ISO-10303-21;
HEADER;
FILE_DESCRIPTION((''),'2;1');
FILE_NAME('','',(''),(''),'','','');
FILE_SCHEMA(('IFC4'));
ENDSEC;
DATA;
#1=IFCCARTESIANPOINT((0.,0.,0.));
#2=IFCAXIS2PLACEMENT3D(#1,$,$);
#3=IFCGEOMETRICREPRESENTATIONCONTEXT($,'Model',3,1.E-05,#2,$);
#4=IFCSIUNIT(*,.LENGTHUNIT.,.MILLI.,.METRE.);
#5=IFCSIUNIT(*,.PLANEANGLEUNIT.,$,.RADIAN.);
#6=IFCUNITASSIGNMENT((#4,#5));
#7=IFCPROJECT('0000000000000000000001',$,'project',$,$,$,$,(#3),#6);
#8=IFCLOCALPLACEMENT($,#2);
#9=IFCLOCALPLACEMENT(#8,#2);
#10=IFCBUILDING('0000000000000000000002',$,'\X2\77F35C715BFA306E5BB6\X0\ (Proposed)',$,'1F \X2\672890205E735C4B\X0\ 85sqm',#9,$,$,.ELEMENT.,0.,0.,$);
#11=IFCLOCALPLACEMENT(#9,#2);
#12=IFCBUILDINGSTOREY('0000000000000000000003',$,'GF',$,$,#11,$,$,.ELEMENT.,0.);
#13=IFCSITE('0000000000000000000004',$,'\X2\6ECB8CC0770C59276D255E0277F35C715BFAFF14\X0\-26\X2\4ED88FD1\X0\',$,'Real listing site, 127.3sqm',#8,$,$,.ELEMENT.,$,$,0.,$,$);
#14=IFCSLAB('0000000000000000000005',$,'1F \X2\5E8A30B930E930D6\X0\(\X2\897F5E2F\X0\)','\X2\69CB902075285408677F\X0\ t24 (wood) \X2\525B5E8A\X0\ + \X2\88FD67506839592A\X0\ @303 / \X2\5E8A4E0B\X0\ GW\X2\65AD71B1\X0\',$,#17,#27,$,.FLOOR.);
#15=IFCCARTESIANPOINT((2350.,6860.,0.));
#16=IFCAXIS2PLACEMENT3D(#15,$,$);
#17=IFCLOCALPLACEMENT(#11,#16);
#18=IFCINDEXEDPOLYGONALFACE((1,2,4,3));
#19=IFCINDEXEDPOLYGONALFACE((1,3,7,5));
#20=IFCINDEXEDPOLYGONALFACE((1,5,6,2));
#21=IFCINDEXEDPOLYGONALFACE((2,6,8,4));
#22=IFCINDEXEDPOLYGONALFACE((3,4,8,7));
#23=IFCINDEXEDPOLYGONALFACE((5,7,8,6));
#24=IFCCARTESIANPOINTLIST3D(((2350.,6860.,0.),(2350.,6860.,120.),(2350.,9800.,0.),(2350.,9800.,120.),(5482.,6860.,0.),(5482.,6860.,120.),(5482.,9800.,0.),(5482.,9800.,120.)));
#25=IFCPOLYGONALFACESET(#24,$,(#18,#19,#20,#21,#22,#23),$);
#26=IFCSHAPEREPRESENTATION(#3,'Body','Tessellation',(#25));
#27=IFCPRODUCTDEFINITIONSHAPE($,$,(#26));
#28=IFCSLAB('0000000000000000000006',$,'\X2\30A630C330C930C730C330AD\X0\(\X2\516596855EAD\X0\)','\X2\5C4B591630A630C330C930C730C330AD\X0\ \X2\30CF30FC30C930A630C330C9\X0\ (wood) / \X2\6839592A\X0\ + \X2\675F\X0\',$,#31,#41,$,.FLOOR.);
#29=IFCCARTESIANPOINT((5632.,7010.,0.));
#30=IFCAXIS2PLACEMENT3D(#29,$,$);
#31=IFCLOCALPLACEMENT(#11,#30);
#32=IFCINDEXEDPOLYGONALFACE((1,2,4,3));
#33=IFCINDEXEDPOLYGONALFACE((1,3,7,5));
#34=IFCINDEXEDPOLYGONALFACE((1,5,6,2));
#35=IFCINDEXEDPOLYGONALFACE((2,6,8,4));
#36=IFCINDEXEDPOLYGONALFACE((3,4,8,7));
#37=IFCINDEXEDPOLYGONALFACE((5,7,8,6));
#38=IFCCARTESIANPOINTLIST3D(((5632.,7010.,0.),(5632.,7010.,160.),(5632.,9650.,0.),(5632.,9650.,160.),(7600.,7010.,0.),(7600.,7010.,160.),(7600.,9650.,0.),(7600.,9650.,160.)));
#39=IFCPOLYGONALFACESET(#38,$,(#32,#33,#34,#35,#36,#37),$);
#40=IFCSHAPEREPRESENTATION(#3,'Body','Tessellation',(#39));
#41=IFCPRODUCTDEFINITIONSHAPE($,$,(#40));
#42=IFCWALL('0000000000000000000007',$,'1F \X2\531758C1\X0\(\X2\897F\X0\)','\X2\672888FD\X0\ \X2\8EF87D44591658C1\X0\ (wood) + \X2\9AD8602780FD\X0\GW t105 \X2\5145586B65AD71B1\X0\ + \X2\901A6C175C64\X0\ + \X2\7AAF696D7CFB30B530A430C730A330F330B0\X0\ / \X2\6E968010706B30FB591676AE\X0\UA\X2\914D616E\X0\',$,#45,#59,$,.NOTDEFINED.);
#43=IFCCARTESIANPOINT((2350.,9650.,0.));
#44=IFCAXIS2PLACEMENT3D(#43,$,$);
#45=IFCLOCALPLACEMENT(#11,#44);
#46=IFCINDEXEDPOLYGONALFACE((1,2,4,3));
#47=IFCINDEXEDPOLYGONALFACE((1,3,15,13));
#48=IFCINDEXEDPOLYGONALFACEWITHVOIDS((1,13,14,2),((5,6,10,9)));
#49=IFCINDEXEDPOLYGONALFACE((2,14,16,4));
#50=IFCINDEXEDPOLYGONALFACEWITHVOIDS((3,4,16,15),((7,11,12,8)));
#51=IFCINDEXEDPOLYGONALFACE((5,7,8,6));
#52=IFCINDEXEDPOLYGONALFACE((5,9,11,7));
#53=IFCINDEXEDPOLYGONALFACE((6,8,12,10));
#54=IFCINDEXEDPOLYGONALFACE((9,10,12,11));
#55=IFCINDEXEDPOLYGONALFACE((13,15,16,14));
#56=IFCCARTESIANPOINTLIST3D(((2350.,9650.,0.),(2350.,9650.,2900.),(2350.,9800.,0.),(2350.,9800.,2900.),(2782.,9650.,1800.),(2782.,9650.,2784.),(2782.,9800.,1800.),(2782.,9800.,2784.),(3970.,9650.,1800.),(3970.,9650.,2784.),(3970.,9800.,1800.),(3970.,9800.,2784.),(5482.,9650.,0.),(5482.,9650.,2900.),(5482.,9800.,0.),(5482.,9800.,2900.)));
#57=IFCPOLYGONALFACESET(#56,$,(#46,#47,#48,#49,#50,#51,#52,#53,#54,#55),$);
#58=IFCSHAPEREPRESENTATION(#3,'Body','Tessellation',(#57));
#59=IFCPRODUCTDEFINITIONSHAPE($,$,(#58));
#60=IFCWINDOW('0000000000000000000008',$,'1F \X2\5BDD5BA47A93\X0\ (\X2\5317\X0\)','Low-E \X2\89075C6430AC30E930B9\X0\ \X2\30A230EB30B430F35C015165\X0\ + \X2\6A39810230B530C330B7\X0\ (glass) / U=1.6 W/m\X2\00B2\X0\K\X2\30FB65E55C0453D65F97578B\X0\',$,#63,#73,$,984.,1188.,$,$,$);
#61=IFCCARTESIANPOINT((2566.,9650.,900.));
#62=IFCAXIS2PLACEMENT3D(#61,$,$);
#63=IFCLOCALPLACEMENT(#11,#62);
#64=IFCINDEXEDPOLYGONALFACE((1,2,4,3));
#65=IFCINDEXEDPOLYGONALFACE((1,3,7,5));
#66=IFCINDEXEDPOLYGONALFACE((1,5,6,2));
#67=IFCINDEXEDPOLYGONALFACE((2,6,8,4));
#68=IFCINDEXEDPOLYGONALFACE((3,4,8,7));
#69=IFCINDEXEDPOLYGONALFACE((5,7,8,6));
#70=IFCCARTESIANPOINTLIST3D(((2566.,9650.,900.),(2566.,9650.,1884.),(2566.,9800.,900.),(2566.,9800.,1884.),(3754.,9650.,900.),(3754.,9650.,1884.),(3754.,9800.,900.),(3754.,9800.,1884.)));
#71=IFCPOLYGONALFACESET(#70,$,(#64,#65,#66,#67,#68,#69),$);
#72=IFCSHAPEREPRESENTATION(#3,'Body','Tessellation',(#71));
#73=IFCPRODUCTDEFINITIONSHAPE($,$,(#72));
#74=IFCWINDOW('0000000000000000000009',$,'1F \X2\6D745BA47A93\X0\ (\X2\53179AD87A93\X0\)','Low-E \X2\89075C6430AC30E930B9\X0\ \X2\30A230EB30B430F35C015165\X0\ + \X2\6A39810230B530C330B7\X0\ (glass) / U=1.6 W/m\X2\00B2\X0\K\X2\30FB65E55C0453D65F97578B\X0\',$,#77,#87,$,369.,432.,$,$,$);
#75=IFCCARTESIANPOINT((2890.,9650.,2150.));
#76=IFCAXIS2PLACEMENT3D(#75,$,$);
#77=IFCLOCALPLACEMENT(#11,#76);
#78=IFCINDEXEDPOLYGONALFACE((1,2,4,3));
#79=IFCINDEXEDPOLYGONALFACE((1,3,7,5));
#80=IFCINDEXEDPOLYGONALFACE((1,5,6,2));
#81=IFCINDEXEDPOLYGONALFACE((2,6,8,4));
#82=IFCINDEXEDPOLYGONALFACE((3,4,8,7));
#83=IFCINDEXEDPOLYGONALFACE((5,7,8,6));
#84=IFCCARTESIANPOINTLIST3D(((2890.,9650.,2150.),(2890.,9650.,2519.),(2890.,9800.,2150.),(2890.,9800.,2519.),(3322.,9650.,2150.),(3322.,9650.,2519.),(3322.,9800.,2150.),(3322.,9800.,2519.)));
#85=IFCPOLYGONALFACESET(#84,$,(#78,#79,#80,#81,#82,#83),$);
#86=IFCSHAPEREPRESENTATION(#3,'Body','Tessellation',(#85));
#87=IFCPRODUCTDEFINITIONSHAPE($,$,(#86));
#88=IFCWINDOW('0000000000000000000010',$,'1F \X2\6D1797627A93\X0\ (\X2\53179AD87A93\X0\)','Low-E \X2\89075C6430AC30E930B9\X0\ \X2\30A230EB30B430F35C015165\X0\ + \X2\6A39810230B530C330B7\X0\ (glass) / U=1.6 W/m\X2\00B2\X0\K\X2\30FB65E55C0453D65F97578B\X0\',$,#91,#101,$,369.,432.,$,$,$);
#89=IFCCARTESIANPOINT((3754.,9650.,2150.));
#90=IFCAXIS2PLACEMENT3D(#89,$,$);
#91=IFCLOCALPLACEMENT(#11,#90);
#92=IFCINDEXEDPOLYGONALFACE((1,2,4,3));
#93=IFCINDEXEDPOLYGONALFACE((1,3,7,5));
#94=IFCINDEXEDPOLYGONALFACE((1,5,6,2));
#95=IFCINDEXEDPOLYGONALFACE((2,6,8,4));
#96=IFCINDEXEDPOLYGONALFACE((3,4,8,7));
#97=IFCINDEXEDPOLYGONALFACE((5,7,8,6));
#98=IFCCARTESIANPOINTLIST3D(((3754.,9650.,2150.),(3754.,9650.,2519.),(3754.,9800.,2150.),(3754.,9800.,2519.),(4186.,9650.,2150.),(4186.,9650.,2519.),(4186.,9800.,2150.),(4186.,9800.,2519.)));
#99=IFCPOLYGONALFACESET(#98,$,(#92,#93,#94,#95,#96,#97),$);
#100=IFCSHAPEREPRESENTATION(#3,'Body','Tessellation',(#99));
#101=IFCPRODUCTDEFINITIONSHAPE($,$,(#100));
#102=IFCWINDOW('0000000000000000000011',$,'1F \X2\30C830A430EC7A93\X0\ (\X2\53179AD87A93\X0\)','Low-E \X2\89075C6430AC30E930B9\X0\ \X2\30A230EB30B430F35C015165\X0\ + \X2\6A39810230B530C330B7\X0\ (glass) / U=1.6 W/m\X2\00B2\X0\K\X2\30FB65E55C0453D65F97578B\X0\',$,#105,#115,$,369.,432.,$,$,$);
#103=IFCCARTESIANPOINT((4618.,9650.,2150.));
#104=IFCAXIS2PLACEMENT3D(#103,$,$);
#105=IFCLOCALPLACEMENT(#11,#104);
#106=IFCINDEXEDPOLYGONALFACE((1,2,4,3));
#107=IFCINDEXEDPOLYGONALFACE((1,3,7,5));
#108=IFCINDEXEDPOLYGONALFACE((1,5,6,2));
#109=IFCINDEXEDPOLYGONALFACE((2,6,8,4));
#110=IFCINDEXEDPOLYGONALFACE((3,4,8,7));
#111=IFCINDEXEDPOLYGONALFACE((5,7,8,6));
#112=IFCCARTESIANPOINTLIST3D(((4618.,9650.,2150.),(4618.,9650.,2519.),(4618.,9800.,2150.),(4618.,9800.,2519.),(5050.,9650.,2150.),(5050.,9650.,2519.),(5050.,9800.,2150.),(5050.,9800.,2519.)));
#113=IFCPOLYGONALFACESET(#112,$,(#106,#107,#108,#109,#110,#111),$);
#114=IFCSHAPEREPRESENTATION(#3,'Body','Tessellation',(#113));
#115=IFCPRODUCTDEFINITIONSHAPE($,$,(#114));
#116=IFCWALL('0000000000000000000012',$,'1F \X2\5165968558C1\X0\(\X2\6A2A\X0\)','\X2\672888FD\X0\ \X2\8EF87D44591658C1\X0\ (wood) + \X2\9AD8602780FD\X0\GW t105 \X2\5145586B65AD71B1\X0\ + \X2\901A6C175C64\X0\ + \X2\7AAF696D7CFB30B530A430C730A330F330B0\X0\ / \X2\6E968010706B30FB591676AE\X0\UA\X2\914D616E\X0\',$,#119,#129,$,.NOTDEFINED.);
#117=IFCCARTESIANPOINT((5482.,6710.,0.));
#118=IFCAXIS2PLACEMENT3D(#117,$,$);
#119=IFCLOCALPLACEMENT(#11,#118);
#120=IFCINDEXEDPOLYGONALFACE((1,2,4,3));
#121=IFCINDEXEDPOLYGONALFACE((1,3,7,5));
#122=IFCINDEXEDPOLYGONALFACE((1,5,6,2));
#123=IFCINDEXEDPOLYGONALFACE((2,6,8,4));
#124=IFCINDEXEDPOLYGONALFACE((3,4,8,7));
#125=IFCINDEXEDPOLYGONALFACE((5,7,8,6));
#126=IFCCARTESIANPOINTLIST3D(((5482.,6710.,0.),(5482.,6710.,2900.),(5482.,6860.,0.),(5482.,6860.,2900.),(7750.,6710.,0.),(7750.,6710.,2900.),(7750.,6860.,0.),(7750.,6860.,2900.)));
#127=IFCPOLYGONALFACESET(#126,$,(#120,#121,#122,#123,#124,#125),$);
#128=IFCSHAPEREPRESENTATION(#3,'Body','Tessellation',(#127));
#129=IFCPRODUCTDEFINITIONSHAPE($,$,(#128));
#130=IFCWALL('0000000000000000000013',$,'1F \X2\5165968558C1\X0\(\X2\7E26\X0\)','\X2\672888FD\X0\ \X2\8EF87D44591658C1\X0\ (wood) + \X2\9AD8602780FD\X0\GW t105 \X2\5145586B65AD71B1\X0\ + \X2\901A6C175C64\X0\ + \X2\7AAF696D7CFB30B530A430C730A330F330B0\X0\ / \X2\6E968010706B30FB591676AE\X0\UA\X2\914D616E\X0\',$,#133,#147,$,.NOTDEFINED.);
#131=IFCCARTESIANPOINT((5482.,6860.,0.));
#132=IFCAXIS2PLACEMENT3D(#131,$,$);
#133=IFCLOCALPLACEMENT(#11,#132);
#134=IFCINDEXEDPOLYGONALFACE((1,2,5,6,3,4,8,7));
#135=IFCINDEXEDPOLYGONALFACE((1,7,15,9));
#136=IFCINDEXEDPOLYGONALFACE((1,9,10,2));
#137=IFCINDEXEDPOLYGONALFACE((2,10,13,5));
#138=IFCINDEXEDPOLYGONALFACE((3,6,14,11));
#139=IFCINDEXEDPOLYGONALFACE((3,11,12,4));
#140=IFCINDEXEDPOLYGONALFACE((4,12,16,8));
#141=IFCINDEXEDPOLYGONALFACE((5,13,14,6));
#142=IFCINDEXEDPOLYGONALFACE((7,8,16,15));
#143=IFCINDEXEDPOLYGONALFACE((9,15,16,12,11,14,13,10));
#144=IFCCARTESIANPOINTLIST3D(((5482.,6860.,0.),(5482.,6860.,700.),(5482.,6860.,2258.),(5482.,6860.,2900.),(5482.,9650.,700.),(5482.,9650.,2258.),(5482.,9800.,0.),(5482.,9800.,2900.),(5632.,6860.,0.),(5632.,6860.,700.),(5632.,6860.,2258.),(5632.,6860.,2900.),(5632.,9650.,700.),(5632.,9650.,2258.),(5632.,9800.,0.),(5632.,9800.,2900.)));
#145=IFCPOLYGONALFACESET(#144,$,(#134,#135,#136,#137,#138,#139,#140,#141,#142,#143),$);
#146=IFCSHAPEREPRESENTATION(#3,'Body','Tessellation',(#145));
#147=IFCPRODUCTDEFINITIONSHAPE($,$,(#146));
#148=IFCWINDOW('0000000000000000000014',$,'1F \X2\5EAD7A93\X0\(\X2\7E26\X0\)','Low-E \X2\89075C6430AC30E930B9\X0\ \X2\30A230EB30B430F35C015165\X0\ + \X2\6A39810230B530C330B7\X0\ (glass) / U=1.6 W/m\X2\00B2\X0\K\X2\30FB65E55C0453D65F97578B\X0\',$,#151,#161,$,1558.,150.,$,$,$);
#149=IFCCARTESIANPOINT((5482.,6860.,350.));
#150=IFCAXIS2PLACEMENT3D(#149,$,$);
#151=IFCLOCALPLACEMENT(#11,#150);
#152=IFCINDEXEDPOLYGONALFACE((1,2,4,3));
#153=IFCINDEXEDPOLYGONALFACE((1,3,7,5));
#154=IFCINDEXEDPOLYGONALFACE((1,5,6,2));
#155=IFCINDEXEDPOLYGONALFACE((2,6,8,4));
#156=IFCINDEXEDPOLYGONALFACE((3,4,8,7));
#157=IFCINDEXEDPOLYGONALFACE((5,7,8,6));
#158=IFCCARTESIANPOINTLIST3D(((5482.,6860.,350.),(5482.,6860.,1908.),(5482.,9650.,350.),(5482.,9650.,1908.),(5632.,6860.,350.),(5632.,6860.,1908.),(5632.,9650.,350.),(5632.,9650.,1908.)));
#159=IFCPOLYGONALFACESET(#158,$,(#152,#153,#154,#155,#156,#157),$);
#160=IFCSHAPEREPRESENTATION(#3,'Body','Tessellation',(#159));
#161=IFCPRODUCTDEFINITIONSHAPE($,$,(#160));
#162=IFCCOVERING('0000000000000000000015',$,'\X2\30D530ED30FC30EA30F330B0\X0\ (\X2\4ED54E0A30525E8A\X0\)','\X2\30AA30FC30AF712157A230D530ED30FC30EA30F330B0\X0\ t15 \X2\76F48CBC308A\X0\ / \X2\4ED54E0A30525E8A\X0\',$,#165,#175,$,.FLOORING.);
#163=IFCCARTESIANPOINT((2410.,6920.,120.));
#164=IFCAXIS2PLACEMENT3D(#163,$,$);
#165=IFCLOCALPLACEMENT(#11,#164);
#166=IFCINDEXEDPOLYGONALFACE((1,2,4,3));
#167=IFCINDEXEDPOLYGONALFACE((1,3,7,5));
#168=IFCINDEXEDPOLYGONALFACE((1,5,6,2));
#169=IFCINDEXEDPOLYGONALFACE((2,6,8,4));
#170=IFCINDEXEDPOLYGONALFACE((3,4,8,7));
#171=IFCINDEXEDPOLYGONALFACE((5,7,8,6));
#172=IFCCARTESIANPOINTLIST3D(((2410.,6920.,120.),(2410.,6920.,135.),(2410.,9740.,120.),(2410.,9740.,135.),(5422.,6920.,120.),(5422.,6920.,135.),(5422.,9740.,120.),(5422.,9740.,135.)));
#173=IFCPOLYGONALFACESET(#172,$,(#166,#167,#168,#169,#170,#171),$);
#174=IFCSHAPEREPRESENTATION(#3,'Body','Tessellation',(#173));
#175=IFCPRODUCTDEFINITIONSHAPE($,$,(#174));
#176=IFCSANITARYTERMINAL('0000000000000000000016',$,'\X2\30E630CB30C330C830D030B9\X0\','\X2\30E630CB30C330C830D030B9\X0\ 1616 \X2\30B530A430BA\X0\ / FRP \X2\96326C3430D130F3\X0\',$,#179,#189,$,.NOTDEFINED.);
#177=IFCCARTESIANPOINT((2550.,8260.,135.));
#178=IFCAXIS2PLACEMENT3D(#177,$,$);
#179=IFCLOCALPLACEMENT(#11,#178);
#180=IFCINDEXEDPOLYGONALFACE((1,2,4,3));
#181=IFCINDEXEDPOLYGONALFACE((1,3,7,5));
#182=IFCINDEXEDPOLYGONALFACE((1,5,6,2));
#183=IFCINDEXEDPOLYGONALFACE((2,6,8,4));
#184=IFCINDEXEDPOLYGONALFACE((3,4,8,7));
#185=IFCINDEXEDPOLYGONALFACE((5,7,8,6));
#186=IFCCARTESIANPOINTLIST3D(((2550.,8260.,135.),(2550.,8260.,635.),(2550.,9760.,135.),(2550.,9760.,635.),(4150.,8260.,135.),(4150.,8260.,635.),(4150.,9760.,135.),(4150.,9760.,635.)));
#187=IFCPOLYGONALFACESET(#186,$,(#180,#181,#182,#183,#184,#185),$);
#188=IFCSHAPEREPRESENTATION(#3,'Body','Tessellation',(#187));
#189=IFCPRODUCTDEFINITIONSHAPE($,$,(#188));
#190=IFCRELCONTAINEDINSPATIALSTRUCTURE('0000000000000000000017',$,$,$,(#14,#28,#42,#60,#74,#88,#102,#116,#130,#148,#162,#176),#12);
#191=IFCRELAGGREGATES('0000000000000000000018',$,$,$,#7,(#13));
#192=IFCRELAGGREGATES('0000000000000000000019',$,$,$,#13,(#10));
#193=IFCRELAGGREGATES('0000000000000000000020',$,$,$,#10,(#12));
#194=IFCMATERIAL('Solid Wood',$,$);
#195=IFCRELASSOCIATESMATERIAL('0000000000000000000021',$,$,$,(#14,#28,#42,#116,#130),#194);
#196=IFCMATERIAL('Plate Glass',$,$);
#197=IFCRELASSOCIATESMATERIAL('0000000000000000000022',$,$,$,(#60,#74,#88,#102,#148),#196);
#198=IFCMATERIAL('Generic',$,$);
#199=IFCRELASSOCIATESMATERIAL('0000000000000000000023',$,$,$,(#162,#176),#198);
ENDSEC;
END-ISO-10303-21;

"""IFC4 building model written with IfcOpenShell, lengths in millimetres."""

from ifc_helpers import new_model, si_unit, frame, frame_2d, origin, place, context, project, spatial, rectangle, extrude, material, element, fill, save


model = new_model("IFC4")

# Units and contexts
model_context = context("Model", 3, precision=1e-05, world=origin())
ifc_project = project(units=[si_unit("LENGTHUNIT", "METRE", prefix="MILLI"), si_unit("PLANEANGLEUNIT", "RADIAN")], contexts=[model_context])

# Site, building, storey
site_placement = place(None, origin())
site = spatial("IfcSite", under=ifc_project, at=site_placement, Name="滋賀県大津市石山寺４-26付近", ObjectType="Real listing site, 127.3sqm", CompositionType="ELEMENT", RefElevation=0.0)
building_placement = place(site_placement, origin())
building = spatial("IfcBuilding", under=site, at=building_placement, Name="石山寺の家 (Proposed)", ObjectType="1F 木造平屋 85sqm", CompositionType="ELEMENT", ElevationOfRefHeight=0.0, ElevationOfTerrain=0.0)
storey_placement = place(building_placement, origin())
storey = spatial("IfcBuildingStorey", under=building, at=storey_placement, Name="GF", CompositionType="ELEMENT", Elevation=0.0)

# Slabs
ifc_material_1 = material(Name="Solid Wood")
slab_1_placement = place(storey_placement, frame((2350.0, 6860.0, 0.0)))
element("IfcSlab", 1, at=slab_1_placement, inside=storey, material=ifc_material_1, Name="1F 床スラブ(西帯)", Description="構造用合板 t24 (wood) 剛床 + 製材根太 @303 / 床下 GW断熱", PredefinedType="FLOOR", context=model_context, shape_type="SweptSolid", body=[
    extrude(rectangle(XDim=3132.0, YDim=2940.0, at=frame_2d((1566.0, 1470.0))), frame((2350.0, 6860.0, 0.0)), (0.0, 0.0, 1.0), 120.0),
])
slab_2_placement = place(storey_placement, frame((5632.0, 7010.0, 0.0)))
element("IfcSlab", 2, at=slab_2_placement, inside=storey, material=ifc_material_1, Name="ウッドデッキ(入隅庭)", Description="屋外ウッドデッキ ハードウッド (wood) / 根太 + 束", PredefinedType="FLOOR", context=model_context, shape_type="SweptSolid", body=[
    extrude(rectangle(XDim=1968.0, YDim=2640.0, at=frame_2d((984.0, 1320.0))), frame((5632.0, 7010.0, 0.0)), (0.0, 0.0, 1.0), 160.0),
])

# Wall, openings, windows
wall_1_placement = place(storey_placement, frame((2350.0, 9650.0, 0.0)))
wall_1 = element("IfcWall", 3, at=wall_1_placement, inside=storey, material=ifc_material_1, Name="1F 北壁(西)", Description="木製 軸組外壁 (wood) + 高性能GW t105 充填断熱 + 通気層 + 窯業系サイディング / 準耐火・外皮UA配慮", PredefinedType="NOTDEFINED", context=model_context, shape_type="SweptSolid", body=[
    extrude(rectangle(XDim=3132.0, YDim=150.0, at=frame_2d((1566.0, 75.0))), frame((2350.0, 9650.0, 0.0)), (0.0, 0.0, 1.0), 2900.0),
])
opening_1_placement = place(storey_placement, frame((2566.0, 9650.0, 900.0)))
opening_1 = element("IfcOpeningElement", 4, at=opening_1_placement, cuts=wall_1, PredefinedType="NOTDEFINED", context=model_context, shape_type="SweptSolid", body=[
    extrude(rectangle(XDim=1188.0, YDim=150.0, at=frame_2d((594.0, 75.0))), frame((2566.0, 9650.0, 900.0)), (0.0, 0.0, 1.0), 984.0),
])
opening_2_placement = place(storey_placement, frame((2890.0, 9650.0, 2150.0)))
opening_2 = element("IfcOpeningElement", 5, at=opening_2_placement, cuts=wall_1, PredefinedType="NOTDEFINED", context=model_context, shape_type="SweptSolid", body=[
    extrude(rectangle(XDim=432.0, YDim=150.0, at=frame_2d((216.0, 75.0))), frame((2890.0, 9650.0, 2150.0)), (0.0, 0.0, 1.0), 369.0),
])
opening_3_placement = place(storey_placement, frame((3754.0, 9650.0, 2150.0)))
opening_3 = element("IfcOpeningElement", 6, at=opening_3_placement, cuts=wall_1, PredefinedType="NOTDEFINED", context=model_context, shape_type="SweptSolid", body=[
    extrude(rectangle(XDim=432.0, YDim=150.0, at=frame_2d((216.0, 75.0))), frame((3754.0, 9650.0, 2150.0)), (0.0, 0.0, 1.0), 369.0),
])
opening_4_placement = place(storey_placement, frame((4618.0, 9650.0, 2150.0)))
opening_4 = element("IfcOpeningElement", 7, at=opening_4_placement, cuts=wall_1, PredefinedType="NOTDEFINED", context=model_context, shape_type="SweptSolid", body=[
    extrude(rectangle(XDim=432.0, YDim=150.0, at=frame_2d((216.0, 75.0))), frame((4618.0, 9650.0, 2150.0)), (0.0, 0.0, 1.0), 369.0),
])
ifc_material_2 = material(Name="Plate Glass")
window_1_placement = place(storey_placement, frame((2566.0, 9650.0, 900.0)))
window_1 = element("IfcWindow", 8, at=window_1_placement, inside=storey, material=ifc_material_2, Name="1F 寝室窓 (北)", Description="Low-E 複層ガラス アルゴン封入 + 樹脂サッシ (glass) / U=1.6 W/m²K・日射取得型", OverallHeight=984.0, OverallWidth=1188.0, context=model_context, shape_type="SweptSolid", body=[
    extrude(rectangle(XDim=1188.0, YDim=150.0, at=frame_2d((594.0, 75.0))), frame((2566.0, 9650.0, 900.0)), (0.0, 0.0, 1.0), 984.0),
])
fill(opening_1, window_1)
window_2_placement = place(storey_placement, frame((2890.0, 9650.0, 2150.0)))
window_2 = element("IfcWindow", 9, at=window_2_placement, inside=storey, material=ifc_material_2, Name="1F 浴室窓 (北高窓)", Description="Low-E 複層ガラス アルゴン封入 + 樹脂サッシ (glass) / U=1.6 W/m²K・日射取得型", OverallHeight=369.0, OverallWidth=432.0, context=model_context, shape_type="SweptSolid", body=[
    extrude(rectangle(XDim=432.0, YDim=150.0, at=frame_2d((216.0, 75.0))), frame((2890.0, 9650.0, 2150.0)), (0.0, 0.0, 1.0), 369.0),
])
fill(opening_2, window_2)
window_3_placement = place(storey_placement, frame((3754.0, 9650.0, 2150.0)))
window_3 = element("IfcWindow", 10, at=window_3_placement, inside=storey, material=ifc_material_2, Name="1F 洗面窓 (北高窓)", Description="Low-E 複層ガラス アルゴン封入 + 樹脂サッシ (glass) / U=1.6 W/m²K・日射取得型", OverallHeight=369.0, OverallWidth=432.0, context=model_context, shape_type="SweptSolid", body=[
    extrude(rectangle(XDim=432.0, YDim=150.0, at=frame_2d((216.0, 75.0))), frame((3754.0, 9650.0, 2150.0)), (0.0, 0.0, 1.0), 369.0),
])
fill(opening_3, window_3)
window_4_placement = place(storey_placement, frame((4618.0, 9650.0, 2150.0)))
window_4 = element("IfcWindow", 11, at=window_4_placement, inside=storey, material=ifc_material_2, Name="1F トイレ窓 (北高窓)", Description="Low-E 複層ガラス アルゴン封入 + 樹脂サッシ (glass) / U=1.6 W/m²K・日射取得型", OverallHeight=369.0, OverallWidth=432.0, context=model_context, shape_type="SweptSolid", body=[
    extrude(rectangle(XDim=432.0, YDim=150.0, at=frame_2d((216.0, 75.0))), frame((4618.0, 9650.0, 2150.0)), (0.0, 0.0, 1.0), 369.0),
])
fill(opening_4, window_4)

# Wall
wall_2_placement = place(storey_placement, frame((5482.0, 6710.0, 0.0)))
element("IfcWall", 12, at=wall_2_placement, inside=storey, material=ifc_material_1, Name="1F 入隅壁(横)", Description="木製 軸組外壁 (wood) + 高性能GW t105 充填断熱 + 通気層 + 窯業系サイディング / 準耐火・外皮UA配慮", PredefinedType="NOTDEFINED", context=model_context, shape_type="SweptSolid", body=[
    extrude(rectangle(XDim=2268.0, YDim=150.0, at=frame_2d((1134.0, 75.0))), frame((5482.0, 6710.0, 0.0)), (0.0, 0.0, 1.0), 2900.0),
])

# Wall, opening, window
wall_3_placement = place(storey_placement, frame((5482.0, 6860.0, 0.0)))
wall_3 = element("IfcWall", 13, at=wall_3_placement, inside=storey, material=ifc_material_1, Name="1F 入隅壁(縦)", Description="木製 軸組外壁 (wood) + 高性能GW t105 充填断熱 + 通気層 + 窯業系サイディング / 準耐火・外皮UA配慮", PredefinedType="NOTDEFINED", context=model_context, shape_type="SweptSolid", body=[
    extrude(rectangle(XDim=150.0, YDim=2940.0, at=frame_2d((75.0, 1470.0))), frame((5482.0, 6860.0, 0.0)), (0.0, 0.0, 1.0), 2900.0),
])
opening_5_placement = place(storey_placement, frame((5482.0, 6860.0, 350.0)))
opening_5 = element("IfcOpeningElement", 14, at=opening_5_placement, cuts=wall_3, PredefinedType="NOTDEFINED", context=model_context, shape_type="SweptSolid", body=[
    extrude(rectangle(XDim=150.0, YDim=2790.0, at=frame_2d((75.0, 1395.0))), frame((5482.0, 6860.0, 350.0)), (0.0, 0.0, 1.0), 1558.0),
])
window_5_placement = place(storey_placement, frame((5482.0, 6860.0, 350.0)))
window_5 = element("IfcWindow", 15, at=window_5_placement, inside=storey, material=ifc_material_2, Name="1F 庭窓(縦)", Description="Low-E 複層ガラス アルゴン封入 + 樹脂サッシ (glass) / U=1.6 W/m²K・日射取得型", OverallHeight=1558.0, OverallWidth=150.0, context=model_context, shape_type="SweptSolid", body=[
    extrude(rectangle(XDim=150.0, YDim=2790.0, at=frame_2d((75.0, 1395.0))), frame((5482.0, 6860.0, 350.0)), (0.0, 0.0, 1.0), 1558.0),
])
fill(opening_5, window_5)

# Covering
ifc_material_3 = material(Name="Generic")
covering_placement = place(storey_placement, frame((2410.0, 6920.0, 120.0)))
element("IfcCovering", 16, at=covering_placement, inside=storey, material=ifc_material_3, Name="フローリング (仕上げ床)", Description="オーク無垢フローリング t15 直貼り / 仕上げ床", PredefinedType="FLOORING", context=model_context, shape_type="SweptSolid", body=[
    extrude(rectangle(XDim=3012.0, YDim=2820.0, at=frame_2d((1506.0, 1410.0))), frame((2410.0, 6920.0, 120.0)), (0.0, 0.0, 1.0), 15.0),
])

# Sanitary terminal
sanitary_terminal_1_placement = place(storey_placement, frame((2550.0, 8260.0, 135.0)))
element("IfcSanitaryTerminal", 17, at=sanitary_terminal_1_placement, inside=storey, material=ifc_material_3, Name="ユニットバス", Description="ユニットバス 1616 サイズ / FRP 防水パン", PredefinedType="NOTDEFINED", context=model_context, shape_type="SweptSolid", body=[
    extrude(rectangle(XDim=1600.0, YDim=1500.0, at=frame_2d((800.0, 750.0))), frame((2550.0, 8260.0, 135.0)), (0.0, 0.0, 1.0), 500.0),
])

save(model, "model.ifc")
